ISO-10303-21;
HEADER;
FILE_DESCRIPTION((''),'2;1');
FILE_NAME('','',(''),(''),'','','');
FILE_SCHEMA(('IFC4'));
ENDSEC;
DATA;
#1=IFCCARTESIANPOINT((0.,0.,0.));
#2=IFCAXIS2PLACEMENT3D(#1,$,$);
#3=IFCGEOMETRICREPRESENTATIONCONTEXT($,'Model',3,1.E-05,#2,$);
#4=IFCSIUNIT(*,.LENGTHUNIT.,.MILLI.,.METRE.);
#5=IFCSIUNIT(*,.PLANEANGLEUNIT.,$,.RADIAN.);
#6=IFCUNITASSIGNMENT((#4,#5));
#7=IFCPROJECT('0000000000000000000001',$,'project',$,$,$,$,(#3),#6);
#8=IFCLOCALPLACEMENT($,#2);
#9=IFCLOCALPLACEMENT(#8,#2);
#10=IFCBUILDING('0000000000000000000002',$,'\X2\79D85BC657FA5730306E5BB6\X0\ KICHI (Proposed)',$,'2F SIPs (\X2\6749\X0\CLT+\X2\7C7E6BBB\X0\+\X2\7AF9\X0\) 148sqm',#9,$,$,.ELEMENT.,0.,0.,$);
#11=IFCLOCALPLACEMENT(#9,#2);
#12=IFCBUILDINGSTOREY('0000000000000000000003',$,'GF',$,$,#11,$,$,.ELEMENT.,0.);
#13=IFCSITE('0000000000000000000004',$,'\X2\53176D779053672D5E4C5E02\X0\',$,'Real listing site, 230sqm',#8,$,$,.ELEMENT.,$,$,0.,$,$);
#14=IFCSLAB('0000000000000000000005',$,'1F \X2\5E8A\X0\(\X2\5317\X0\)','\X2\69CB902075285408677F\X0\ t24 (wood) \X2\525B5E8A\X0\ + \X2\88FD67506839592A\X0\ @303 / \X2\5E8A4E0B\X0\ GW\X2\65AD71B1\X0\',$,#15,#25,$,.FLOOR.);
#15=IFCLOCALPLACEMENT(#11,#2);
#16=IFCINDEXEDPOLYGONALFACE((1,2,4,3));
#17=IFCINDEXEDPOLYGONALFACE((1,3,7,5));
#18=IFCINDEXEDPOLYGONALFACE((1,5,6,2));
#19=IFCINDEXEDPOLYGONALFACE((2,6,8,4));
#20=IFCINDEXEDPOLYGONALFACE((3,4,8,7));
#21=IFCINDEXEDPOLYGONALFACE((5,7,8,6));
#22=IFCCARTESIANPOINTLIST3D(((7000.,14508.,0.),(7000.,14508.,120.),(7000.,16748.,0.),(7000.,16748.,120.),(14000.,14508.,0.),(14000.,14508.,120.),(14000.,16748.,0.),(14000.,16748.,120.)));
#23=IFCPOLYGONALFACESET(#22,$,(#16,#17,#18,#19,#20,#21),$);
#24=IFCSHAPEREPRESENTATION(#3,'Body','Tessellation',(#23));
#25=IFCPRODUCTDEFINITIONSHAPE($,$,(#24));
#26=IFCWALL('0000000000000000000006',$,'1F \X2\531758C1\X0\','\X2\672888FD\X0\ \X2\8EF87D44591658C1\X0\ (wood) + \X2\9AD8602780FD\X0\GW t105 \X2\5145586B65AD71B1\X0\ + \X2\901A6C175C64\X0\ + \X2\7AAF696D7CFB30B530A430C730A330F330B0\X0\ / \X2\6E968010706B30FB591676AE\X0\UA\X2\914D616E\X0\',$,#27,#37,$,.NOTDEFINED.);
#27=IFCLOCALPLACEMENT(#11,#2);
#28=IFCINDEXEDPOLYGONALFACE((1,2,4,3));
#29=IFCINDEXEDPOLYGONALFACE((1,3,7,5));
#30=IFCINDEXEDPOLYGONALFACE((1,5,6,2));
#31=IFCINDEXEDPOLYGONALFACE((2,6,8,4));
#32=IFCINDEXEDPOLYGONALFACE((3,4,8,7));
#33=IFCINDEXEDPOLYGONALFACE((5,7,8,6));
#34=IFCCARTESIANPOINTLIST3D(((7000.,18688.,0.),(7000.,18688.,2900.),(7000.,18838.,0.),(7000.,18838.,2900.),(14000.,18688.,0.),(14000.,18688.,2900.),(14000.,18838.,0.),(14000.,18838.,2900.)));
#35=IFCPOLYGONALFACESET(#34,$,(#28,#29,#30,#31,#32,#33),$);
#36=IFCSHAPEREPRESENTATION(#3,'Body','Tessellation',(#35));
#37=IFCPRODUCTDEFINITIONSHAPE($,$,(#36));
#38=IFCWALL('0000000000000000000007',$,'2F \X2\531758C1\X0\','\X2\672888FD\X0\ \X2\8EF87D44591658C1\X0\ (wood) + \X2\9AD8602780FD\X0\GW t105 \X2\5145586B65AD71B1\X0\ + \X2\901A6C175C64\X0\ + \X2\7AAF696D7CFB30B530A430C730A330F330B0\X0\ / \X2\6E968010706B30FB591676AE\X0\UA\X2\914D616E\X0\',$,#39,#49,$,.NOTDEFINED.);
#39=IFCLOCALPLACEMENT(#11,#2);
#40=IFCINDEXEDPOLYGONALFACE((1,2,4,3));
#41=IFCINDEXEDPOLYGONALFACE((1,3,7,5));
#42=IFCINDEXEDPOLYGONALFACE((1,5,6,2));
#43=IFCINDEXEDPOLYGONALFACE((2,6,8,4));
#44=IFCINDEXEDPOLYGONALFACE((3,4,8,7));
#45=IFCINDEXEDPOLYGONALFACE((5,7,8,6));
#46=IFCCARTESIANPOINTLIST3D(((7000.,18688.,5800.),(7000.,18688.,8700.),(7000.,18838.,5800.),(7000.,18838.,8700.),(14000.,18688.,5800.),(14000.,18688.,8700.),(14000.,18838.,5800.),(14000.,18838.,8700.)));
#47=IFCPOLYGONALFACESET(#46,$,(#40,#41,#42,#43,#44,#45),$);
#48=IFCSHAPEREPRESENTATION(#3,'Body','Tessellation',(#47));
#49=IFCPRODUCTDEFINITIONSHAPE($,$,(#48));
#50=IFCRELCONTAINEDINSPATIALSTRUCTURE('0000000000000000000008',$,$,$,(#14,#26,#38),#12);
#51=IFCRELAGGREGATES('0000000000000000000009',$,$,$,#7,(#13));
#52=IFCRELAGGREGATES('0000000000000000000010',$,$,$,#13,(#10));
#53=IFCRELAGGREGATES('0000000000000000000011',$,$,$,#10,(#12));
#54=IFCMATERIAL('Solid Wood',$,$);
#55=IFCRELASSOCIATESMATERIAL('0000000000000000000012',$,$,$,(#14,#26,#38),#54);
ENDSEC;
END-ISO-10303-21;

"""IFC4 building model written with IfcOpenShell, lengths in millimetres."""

from ifc_helpers import new_model, si_unit, frame, frame_2d, origin, place, context, project, spatial, rectangle, extrude, material, element, save


model = new_model("IFC4")

# Units and contexts
model_context = context("Model", 3, precision=1e-05, world=origin())
ifc_project = project(units=[si_unit("LENGTHUNIT", "METRE", prefix="MILLI"), si_unit("PLANEANGLEUNIT", "RADIAN")], contexts=[model_context])

# Site, building, storey
site_placement = place(None, origin())
site = spatial("IfcSite", under=ifc_project, at=site_placement, Name="北海道札幌市", ObjectType="Real listing site, 230sqm", CompositionType="ELEMENT", RefElevation=0.0)
building_placement = place(site_placement, origin())
building = spatial("IfcBuilding", under=site, at=building_placement, Name="秘密基地の家 KICHI (Proposed)", ObjectType="2F SIPs (杉CLT+籾殻+竹) 148sqm", CompositionType="ELEMENT", ElevationOfRefHeight=0.0, ElevationOfTerrain=0.0)
storey_placement = place(building_placement, origin())
storey = spatial("IfcBuildingStorey", under=building, at=storey_placement, Name="GF", CompositionType="ELEMENT", Elevation=0.0)

# Slab
ifc_material_1 = material(Name="Solid Wood")
slab_1_placement = place(storey_placement, frame((3500.0, 7254.0, 0.0)))
element("IfcSlab", 1, at=slab_1_placement, inside=storey, material=ifc_material_1, Name="1F 床(北)", Description="構造用合板 t24 (wood) 剛床 + 製材根太 @303 / 床下 GW断熱", PredefinedType="FLOOR", context=model_context, shape_type="SweptSolid", body=[
    extrude(rectangle(XDim=7000.0, YDim=2240.0, at=frame_2d((3500.0, 1120.0))), frame((3500.0, 7254.0, 0.0)), (0.0, 0.0, 1.0), 120.0),
])

# Wall
wall_1_placement = place(storey_placement, frame((3500.0, 9344.0, 0.0)))
element("IfcWall", 2, at=wall_1_placement, inside=storey, material=ifc_material_1, Name="1F 北壁", Description="木製 軸組外壁 (wood) + 高性能GW t105 充填断熱 + 通気層 + 窯業系サイディング / 準耐火・外皮UA配慮", PredefinedType="NOTDEFINED", context=model_context, shape_type="SweptSolid", body=[
    extrude(rectangle(XDim=7000.0, YDim=150.0, at=frame_2d((3500.0, 75.0))), frame((3500.0, 9344.0, 0.0)), (0.0, 0.0, 1.0), 2900.0),
])

# Wall
wall_2_placement = place(storey_placement, frame((3500.0, 9344.0, 2900.0)))
element("IfcWall", 3, at=wall_2_placement, inside=storey, material=ifc_material_1, Name="2F 北壁", Description="木製 軸組外壁 (wood) + 高性能GW t105 充填断熱 + 通気層 + 窯業系サイディング / 準耐火・外皮UA配慮", PredefinedType="NOTDEFINED", context=model_context, shape_type="SweptSolid", body=[
    extrude(rectangle(XDim=7000.0, YDim=150.0, at=frame_2d((3500.0, 75.0))), frame((3500.0, 9344.0, 2900.0)), (0.0, 0.0, 1.0), 2900.0),
])

save(model, "model.ifc")
